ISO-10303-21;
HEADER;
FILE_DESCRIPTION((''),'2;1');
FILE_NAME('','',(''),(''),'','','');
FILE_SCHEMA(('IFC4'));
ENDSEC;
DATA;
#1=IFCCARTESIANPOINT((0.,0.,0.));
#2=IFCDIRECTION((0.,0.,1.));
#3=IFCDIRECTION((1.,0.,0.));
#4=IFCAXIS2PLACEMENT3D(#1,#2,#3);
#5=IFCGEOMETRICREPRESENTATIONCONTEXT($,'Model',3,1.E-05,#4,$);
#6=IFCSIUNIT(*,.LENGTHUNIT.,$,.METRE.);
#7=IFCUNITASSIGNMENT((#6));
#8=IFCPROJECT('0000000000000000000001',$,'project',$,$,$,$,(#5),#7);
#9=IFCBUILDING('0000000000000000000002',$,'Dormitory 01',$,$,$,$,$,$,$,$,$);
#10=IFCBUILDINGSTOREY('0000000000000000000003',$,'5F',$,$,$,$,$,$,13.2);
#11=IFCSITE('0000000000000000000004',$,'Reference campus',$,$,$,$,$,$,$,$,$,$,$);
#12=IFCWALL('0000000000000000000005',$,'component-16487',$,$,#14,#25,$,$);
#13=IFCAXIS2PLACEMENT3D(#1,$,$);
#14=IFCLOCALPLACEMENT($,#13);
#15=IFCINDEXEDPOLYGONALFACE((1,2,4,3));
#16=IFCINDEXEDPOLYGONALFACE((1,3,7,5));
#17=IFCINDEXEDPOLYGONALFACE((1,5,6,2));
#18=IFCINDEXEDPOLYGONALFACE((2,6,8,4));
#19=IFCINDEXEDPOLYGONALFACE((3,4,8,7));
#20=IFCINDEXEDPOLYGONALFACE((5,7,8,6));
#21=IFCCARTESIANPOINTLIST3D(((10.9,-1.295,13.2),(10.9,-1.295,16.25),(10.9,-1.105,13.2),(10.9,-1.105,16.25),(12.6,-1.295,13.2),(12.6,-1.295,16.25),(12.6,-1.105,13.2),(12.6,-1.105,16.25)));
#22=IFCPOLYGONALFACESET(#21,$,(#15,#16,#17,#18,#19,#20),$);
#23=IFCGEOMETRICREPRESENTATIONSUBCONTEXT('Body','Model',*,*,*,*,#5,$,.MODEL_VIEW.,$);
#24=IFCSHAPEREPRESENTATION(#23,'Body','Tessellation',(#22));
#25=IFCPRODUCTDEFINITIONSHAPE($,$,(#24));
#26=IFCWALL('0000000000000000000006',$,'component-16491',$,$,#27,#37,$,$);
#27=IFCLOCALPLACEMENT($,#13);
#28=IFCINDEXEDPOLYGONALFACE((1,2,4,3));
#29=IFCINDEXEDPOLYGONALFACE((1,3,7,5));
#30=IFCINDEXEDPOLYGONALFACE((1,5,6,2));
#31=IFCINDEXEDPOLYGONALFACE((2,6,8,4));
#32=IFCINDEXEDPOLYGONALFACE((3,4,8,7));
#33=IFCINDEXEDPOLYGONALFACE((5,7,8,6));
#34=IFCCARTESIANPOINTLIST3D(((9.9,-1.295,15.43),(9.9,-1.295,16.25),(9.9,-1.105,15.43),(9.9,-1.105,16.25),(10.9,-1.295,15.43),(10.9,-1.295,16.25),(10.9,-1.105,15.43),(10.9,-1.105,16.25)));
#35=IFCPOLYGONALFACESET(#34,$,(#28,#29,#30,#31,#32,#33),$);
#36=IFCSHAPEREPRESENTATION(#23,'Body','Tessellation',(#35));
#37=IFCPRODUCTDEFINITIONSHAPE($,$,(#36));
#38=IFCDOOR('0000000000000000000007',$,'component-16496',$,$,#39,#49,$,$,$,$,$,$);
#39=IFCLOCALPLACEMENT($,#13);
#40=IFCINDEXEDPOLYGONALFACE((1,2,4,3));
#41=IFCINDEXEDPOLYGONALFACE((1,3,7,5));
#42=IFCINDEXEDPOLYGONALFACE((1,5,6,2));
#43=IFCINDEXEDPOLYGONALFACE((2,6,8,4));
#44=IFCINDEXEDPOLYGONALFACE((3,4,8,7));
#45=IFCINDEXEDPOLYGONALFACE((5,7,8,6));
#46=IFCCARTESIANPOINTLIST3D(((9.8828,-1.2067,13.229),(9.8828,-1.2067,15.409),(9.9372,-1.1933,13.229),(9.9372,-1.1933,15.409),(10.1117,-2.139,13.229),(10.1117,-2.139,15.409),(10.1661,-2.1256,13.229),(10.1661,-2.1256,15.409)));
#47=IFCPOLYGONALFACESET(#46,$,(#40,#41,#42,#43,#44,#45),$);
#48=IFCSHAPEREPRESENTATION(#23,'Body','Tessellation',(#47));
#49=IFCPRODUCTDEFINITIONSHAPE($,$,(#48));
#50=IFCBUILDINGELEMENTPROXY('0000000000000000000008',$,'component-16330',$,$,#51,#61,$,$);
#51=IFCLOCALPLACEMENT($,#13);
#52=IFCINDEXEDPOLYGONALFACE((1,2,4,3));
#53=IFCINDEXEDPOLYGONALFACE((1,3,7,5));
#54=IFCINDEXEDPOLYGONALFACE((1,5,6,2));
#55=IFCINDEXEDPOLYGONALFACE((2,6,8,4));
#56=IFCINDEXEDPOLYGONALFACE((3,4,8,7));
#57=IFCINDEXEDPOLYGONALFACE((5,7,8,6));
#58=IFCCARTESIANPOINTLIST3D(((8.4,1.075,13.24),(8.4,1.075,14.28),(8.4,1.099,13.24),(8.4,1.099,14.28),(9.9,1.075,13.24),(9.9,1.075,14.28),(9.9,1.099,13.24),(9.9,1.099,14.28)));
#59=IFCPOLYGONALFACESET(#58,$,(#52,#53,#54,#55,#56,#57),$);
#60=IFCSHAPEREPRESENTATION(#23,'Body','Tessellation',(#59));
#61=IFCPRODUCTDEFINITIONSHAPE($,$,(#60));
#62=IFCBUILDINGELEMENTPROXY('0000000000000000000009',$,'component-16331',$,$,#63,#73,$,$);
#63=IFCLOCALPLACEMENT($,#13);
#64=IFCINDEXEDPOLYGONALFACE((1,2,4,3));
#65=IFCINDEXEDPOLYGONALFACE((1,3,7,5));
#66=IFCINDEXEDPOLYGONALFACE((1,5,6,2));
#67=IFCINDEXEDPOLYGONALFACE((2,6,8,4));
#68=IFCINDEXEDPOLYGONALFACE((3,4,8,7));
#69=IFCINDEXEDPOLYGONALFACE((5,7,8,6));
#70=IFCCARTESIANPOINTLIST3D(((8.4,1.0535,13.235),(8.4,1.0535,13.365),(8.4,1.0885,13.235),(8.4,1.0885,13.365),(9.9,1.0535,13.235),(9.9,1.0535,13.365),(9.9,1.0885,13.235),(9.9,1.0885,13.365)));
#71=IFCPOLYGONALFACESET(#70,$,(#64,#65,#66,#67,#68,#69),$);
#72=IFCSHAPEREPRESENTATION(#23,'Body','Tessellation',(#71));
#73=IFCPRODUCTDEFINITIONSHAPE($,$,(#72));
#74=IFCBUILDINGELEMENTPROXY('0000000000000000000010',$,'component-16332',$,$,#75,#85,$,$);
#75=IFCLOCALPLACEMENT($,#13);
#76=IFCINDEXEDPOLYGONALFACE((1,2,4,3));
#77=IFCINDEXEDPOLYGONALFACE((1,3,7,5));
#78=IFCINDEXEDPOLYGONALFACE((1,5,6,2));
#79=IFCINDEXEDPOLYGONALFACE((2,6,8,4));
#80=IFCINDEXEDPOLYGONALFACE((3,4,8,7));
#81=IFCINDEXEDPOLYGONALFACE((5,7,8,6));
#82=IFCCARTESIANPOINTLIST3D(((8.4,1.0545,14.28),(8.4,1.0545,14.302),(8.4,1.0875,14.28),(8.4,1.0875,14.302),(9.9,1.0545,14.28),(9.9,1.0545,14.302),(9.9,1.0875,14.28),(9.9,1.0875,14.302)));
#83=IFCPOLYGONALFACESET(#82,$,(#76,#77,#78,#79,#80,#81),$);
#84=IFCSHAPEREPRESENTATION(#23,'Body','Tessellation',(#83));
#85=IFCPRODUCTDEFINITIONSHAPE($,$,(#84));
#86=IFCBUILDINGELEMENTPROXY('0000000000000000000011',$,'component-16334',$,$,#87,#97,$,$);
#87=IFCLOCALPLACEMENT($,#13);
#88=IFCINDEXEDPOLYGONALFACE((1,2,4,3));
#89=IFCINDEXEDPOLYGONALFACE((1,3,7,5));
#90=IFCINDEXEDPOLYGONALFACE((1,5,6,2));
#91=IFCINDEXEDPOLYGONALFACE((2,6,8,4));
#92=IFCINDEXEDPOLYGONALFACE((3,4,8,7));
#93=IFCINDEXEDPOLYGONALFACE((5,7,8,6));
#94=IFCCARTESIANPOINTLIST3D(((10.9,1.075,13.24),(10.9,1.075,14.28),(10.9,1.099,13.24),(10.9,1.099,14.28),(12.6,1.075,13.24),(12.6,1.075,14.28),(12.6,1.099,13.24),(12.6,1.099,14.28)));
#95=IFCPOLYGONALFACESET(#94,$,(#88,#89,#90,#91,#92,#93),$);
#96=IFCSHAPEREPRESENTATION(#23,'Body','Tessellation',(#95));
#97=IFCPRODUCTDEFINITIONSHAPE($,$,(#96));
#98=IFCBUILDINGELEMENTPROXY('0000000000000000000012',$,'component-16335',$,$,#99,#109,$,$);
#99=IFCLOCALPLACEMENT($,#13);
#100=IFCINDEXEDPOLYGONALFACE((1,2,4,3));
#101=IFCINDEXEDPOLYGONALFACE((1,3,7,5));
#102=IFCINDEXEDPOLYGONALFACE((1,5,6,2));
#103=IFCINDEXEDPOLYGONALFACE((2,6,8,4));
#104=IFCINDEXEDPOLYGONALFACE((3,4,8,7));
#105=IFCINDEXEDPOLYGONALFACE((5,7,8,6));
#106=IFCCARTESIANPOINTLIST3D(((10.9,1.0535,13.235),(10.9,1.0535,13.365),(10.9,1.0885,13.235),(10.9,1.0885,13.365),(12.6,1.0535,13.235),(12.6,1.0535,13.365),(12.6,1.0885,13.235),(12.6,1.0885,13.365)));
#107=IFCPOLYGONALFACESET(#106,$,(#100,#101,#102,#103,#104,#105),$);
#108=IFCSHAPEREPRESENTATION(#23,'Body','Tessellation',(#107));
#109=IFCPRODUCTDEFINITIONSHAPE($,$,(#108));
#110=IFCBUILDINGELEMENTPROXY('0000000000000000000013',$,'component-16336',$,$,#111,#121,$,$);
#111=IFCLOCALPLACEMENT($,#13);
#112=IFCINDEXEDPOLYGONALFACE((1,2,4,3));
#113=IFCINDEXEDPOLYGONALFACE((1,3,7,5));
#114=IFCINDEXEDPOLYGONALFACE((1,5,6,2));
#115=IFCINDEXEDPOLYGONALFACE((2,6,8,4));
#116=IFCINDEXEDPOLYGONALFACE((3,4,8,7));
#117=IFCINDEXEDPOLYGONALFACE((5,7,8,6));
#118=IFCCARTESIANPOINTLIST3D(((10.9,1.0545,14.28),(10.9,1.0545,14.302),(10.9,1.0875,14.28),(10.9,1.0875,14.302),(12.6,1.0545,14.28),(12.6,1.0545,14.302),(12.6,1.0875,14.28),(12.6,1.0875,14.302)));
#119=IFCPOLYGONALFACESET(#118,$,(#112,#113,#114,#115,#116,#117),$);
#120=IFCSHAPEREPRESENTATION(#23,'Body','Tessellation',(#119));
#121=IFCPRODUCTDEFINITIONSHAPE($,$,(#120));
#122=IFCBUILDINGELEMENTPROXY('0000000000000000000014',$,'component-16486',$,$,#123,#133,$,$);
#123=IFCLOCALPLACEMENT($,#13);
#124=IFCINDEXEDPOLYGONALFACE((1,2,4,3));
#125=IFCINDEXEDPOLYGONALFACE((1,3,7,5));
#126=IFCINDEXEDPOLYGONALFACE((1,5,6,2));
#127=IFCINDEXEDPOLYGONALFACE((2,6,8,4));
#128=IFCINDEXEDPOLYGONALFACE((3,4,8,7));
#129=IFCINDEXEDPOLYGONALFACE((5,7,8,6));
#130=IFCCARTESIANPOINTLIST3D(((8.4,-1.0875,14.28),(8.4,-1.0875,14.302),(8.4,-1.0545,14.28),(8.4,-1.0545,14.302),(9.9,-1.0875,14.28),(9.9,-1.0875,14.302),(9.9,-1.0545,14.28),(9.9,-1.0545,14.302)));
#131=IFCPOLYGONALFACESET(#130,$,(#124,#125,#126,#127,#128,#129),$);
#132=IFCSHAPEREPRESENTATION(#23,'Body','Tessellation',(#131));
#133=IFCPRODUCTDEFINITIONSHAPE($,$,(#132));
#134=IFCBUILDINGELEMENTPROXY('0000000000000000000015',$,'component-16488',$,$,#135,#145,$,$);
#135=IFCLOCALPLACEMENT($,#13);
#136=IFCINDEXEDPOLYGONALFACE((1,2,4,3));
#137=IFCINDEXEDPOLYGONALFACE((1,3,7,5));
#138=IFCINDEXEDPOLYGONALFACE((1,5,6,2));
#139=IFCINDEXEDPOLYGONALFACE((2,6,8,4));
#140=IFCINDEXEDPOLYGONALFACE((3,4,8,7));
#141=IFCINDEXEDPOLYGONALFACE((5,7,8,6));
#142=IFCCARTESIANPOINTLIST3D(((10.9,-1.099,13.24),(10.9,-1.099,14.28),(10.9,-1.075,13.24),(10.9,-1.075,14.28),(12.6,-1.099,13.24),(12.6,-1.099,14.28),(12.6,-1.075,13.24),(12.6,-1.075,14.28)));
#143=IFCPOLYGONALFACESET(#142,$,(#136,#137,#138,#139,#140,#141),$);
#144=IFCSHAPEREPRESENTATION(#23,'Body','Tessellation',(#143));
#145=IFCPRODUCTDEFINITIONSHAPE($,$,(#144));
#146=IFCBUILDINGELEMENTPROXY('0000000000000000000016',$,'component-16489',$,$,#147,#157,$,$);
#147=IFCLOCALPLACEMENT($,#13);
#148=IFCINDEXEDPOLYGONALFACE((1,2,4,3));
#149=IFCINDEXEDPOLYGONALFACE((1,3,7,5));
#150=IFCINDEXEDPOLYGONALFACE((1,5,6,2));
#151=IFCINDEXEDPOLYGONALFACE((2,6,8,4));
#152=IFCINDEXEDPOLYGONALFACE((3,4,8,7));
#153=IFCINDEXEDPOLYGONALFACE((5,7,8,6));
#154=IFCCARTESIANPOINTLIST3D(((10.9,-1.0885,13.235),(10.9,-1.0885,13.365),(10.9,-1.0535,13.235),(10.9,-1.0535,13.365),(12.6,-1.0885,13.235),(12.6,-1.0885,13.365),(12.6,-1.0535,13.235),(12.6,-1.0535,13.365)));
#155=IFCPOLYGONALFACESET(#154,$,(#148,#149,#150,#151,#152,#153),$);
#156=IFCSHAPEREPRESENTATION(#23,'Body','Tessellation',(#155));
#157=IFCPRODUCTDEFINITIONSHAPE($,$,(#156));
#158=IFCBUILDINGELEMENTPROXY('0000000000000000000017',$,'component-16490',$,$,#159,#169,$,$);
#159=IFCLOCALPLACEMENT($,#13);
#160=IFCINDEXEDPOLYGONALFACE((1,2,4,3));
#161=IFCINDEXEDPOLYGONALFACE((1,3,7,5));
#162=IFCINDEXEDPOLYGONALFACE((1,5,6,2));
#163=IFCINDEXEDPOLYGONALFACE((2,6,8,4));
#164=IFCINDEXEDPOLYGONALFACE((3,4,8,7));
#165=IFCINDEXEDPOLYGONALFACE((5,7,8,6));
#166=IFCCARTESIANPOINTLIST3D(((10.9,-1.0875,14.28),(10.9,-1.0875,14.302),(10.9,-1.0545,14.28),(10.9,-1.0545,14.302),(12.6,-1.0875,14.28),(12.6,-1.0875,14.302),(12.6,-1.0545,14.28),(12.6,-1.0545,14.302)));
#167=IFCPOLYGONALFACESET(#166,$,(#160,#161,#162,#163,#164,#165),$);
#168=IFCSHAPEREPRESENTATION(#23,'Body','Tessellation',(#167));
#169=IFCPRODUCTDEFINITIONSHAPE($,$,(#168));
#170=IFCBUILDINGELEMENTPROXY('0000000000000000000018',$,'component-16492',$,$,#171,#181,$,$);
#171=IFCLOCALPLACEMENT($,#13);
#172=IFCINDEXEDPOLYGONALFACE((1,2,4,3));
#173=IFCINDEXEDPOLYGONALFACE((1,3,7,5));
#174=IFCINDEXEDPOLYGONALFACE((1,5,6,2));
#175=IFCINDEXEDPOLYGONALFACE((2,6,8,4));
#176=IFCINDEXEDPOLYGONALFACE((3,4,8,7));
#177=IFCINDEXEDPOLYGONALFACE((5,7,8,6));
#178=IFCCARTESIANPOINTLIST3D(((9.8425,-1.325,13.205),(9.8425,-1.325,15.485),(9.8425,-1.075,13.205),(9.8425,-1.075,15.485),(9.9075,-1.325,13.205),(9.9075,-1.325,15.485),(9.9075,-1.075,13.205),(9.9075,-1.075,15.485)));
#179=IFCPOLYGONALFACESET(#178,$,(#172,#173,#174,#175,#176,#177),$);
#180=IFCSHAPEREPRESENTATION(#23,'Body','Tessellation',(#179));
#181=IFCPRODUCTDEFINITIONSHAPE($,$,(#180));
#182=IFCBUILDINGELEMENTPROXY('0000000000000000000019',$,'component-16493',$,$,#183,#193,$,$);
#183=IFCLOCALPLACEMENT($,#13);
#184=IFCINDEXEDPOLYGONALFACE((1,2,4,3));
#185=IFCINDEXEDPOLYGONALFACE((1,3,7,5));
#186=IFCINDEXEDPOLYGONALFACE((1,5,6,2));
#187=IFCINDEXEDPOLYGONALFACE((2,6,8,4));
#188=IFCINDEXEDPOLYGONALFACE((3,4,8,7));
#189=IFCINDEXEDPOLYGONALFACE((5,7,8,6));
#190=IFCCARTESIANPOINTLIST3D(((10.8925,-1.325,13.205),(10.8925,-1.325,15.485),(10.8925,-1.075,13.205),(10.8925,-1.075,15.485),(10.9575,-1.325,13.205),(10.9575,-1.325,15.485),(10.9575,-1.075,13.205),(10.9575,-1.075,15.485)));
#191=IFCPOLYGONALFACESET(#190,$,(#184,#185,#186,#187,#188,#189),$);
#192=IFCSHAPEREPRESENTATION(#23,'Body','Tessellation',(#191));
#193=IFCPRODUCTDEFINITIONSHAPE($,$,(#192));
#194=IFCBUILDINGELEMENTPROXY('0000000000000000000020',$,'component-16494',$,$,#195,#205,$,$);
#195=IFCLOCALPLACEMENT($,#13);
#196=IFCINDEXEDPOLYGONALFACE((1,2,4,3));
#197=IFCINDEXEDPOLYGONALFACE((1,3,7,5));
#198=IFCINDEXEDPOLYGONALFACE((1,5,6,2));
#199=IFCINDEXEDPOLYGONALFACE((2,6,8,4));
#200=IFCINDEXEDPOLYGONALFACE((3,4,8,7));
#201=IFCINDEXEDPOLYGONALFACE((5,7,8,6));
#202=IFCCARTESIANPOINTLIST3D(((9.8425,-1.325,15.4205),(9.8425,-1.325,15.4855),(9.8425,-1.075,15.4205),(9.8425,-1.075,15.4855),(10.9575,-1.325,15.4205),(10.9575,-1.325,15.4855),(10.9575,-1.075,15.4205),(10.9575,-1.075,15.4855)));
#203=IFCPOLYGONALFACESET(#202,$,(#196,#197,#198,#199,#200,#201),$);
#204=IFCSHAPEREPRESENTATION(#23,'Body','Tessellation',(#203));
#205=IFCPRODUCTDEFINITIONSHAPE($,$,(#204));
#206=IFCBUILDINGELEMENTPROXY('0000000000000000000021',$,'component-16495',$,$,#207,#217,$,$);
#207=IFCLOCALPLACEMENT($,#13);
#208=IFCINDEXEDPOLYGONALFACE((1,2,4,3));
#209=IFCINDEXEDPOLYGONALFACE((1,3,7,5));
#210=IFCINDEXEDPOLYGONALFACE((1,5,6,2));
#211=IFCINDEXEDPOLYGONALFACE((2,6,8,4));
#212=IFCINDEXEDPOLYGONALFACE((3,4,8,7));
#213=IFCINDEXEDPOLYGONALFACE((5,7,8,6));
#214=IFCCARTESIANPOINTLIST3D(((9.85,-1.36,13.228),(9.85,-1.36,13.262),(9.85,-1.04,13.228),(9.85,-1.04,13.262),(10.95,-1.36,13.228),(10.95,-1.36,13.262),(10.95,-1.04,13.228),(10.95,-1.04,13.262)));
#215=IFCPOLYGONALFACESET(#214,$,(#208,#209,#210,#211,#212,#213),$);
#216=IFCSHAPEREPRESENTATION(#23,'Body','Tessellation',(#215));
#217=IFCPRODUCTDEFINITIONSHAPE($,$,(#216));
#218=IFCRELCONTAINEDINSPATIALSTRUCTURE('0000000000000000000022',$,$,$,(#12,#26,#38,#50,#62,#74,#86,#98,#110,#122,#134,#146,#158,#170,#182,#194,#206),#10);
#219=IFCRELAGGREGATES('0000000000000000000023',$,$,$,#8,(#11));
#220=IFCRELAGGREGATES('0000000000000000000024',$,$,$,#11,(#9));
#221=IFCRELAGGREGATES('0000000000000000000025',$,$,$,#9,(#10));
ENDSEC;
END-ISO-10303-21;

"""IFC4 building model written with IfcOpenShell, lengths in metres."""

from ifc_helpers import new_model, si_unit, frame, origin, origin_with_axes, origin_2d, place, context, subcontext, project, spatial, rectangle, extrude, element, save


model = new_model("IFC4")

# Units and contexts
model_context = context("Model", 3, precision=1e-05, world=origin_with_axes())
body_context = subcontext(model_context, "Body", "Model", "MODEL_VIEW")
ifc_project = project(units=[si_unit("LENGTHUNIT", "METRE")], contexts=[model_context])

# Site, building, storey
site = spatial("IfcSite", under=ifc_project, Name="Reference campus")
building = spatial("IfcBuilding", under=site, Name="Dormitory 01")
storey = spatial("IfcBuildingStorey", under=building, Name="5F", Elevation=13.2)

# Walls
wall_1_placement = place(None, frame((11.75, -1.2, 13.2), z_axis=(0.0, 0.0, 1.0), x_axis=(1.0, 0.0, 0.0)))
element("IfcWall", 1, at=wall_1_placement, inside=storey, Name="component-16487", context=body_context, shape_type="SweptSolid", body=[
    extrude(rectangle(XDim=1.7, YDim=0.19, at=origin_2d()), origin(), (0.0, 0.0, 1.0), 3.05),
])
wall_2_placement = place(None, frame((10.4, -1.2, 15.43), z_axis=(0.0, 0.0, 1.0), x_axis=(1.0, 0.0, 0.0)))
element("IfcWall", 2, at=wall_2_placement, inside=storey, Name="component-16491", context=body_context, shape_type="SweptSolid", body=[
    extrude(rectangle(XDim=1.0, YDim=0.19, at=origin_2d()), origin(), (0.0, 0.0, 1.0), 0.82),
])

# Door
door_placement = place(None, frame((10.0245, -1.6662, 13.229), z_axis=(0.0, 0.0, 1.0), x_axis=(0.238476, -0.971148, 0.0)))
element("IfcDoor", 3, at=door_placement, inside=storey, Name="component-16496", context=body_context, shape_type="SweptSolid", body=[
    extrude(rectangle(XDim=0.96, YDim=0.056, at=origin_2d()), origin(), (0.0, 0.0, 1.0), 2.18),
])

# Building element proxies
proxy_1_placement = place(None, frame((9.15, 1.087, 13.24), z_axis=(0.0, 0.0, 1.0), x_axis=(1.0, 0.0, 0.0)))
element("IfcBuildingElementProxy", 4, at=proxy_1_placement, inside=storey, Name="component-16330", context=body_context, shape_type="SweptSolid", body=[
    extrude(rectangle(XDim=1.5, YDim=0.024, at=origin_2d()), origin(), (0.0, 0.0, 1.0), 1.04),
])
proxy_2_placement = place(None, frame((9.15, 1.071, 13.235), z_axis=(0.0, 0.0, 1.0), x_axis=(1.0, 0.0, 0.0)))
element("IfcBuildingElementProxy", 5, at=proxy_2_placement, inside=storey, Name="component-16331", context=body_context, shape_type="SweptSolid", body=[
    extrude(rectangle(XDim=1.5, YDim=0.035, at=origin_2d()), origin(), (0.0, 0.0, 1.0), 0.13),
])
proxy_3_placement = place(None, frame((9.15, 1.071, 14.28), z_axis=(0.0, 0.0, 1.0), x_axis=(1.0, 0.0, 0.0)))
element("IfcBuildingElementProxy", 6, at=proxy_3_placement, inside=storey, Name="component-16332", context=body_context, shape_type="SweptSolid", body=[
    extrude(rectangle(XDim=1.5, YDim=0.033, at=origin_2d()), origin(), (0.0, 0.0, 1.0), 0.022),
])
proxy_4_placement = place(None, frame((11.75, 1.087, 13.24), z_axis=(0.0, 0.0, 1.0), x_axis=(1.0, 0.0, 0.0)))
element("IfcBuildingElementProxy", 7, at=proxy_4_placement, inside=storey, Name="component-16334", context=body_context, shape_type="SweptSolid", body=[
    extrude(rectangle(XDim=1.7, YDim=0.024, at=origin_2d()), origin(), (0.0, 0.0, 1.0), 1.04),
])
proxy_5_placement = place(None, frame((11.75, 1.071, 13.235), z_axis=(0.0, 0.0, 1.0), x_axis=(1.0, 0.0, 0.0)))
element("IfcBuildingElementProxy", 8, at=proxy_5_placement, inside=storey, Name="component-16335", context=body_context, shape_type="SweptSolid", body=[
    extrude(rectangle(XDim=1.7, YDim=0.035, at=origin_2d()), origin(), (0.0, 0.0, 1.0), 0.13),
])
proxy_6_placement = place(None, frame((11.75, 1.071, 14.28), z_axis=(0.0, 0.0, 1.0), x_axis=(1.0, 0.0, 0.0)))
element("IfcBuildingElementProxy", 9, at=proxy_6_placement, inside=storey, Name="component-16336", context=body_context, shape_type="SweptSolid", body=[
    extrude(rectangle(XDim=1.7, YDim=0.033, at=origin_2d()), origin(), (0.0, 0.0, 1.0), 0.022),
])
proxy_7_placement = place(None, frame((9.15, -1.071, 14.28), z_axis=(0.0, 0.0, 1.0), x_axis=(1.0, 0.0, 0.0)))
element("IfcBuildingElementProxy", 10, at=proxy_7_placement, inside=storey, Name="component-16486", context=body_context, shape_type="SweptSolid", body=[
    extrude(rectangle(XDim=1.5, YDim=0.033, at=origin_2d()), origin(), (0.0, 0.0, 1.0), 0.022),
])
proxy_8_placement = place(None, frame((11.75, -1.087, 13.24), z_axis=(0.0, 0.0, 1.0), x_axis=(1.0, 0.0, 0.0)))
element("IfcBuildingElementProxy", 11, at=proxy_8_placement, inside=storey, Name="component-16488", context=body_context, shape_type="SweptSolid", body=[
    extrude(rectangle(XDim=1.7, YDim=0.024, at=origin_2d()), origin(), (0.0, 0.0, 1.0), 1.04),
])
proxy_9_placement = place(None, frame((11.75, -1.071, 13.235), z_axis=(0.0, 0.0, 1.0), x_axis=(1.0, 0.0, 0.0)))
element("IfcBuildingElementProxy", 12, at=proxy_9_placement, inside=storey, Name="component-16489", context=body_context, shape_type="SweptSolid", body=[
    extrude(rectangle(XDim=1.7, YDim=0.035, at=origin_2d()), origin(), (0.0, 0.0, 1.0), 0.13),
])
proxy_10_placement = place(None, frame((11.75, -1.071, 14.28), z_axis=(0.0, 0.0, 1.0), x_axis=(1.0, 0.0, 0.0)))
element("IfcBuildingElementProxy", 13, at=proxy_10_placement, inside=storey, Name="component-16490", context=body_context, shape_type="SweptSolid", body=[
    extrude(rectangle(XDim=1.7, YDim=0.033, at=origin_2d()), origin(), (0.0, 0.0, 1.0), 0.022),
])
for number, where, z_axis, x_axis, name in (
    (14, (9.875, -1.2, 13.205), (0.0, 0.0, 1.0), (1.0, 0.0, 0.0), "component-16492"),
    (15, (10.925, -1.2, 13.205), (0.0, 0.0, 1.0), (1.0, 0.0, 0.0), "component-16493"),
):
    element("IfcBuildingElementProxy", number, at=place(None, frame(where, z_axis=z_axis, x_axis=x_axis)), inside=storey, Name=name, context=body_context, shape_type="SweptSolid", body=[
        extrude(rectangle(XDim=0.065, YDim=0.25, at=origin_2d()), origin(), (0.0, 0.0, 1.0), 2.28),
    ])
proxy_11_placement = place(None, frame((10.4, -1.2, 15.4205), z_axis=(0.0, 0.0, 1.0), x_axis=(1.0, 0.0, 0.0)))
element("IfcBuildingElementProxy", 16, at=proxy_11_placement, inside=storey, Name="component-16494", context=body_context, shape_type="SweptSolid", body=[
    extrude(rectangle(XDim=1.115, YDim=0.25, at=origin_2d()), origin(), (0.0, 0.0, 1.0), 0.065),
])
proxy_12_placement = place(None, frame((10.4, -1.2, 13.228), z_axis=(0.0, 0.0, 1.0), x_axis=(1.0, 0.0, 0.0)))
element("IfcBuildingElementProxy", 17, at=proxy_12_placement, inside=storey, Name="component-16495", context=body_context, shape_type="SweptSolid", body=[
    extrude(rectangle(XDim=1.1, YDim=0.32, at=origin_2d()), origin(), (0.0, 0.0, 1.0), 0.034),
])

save(model, "model.ifc")
